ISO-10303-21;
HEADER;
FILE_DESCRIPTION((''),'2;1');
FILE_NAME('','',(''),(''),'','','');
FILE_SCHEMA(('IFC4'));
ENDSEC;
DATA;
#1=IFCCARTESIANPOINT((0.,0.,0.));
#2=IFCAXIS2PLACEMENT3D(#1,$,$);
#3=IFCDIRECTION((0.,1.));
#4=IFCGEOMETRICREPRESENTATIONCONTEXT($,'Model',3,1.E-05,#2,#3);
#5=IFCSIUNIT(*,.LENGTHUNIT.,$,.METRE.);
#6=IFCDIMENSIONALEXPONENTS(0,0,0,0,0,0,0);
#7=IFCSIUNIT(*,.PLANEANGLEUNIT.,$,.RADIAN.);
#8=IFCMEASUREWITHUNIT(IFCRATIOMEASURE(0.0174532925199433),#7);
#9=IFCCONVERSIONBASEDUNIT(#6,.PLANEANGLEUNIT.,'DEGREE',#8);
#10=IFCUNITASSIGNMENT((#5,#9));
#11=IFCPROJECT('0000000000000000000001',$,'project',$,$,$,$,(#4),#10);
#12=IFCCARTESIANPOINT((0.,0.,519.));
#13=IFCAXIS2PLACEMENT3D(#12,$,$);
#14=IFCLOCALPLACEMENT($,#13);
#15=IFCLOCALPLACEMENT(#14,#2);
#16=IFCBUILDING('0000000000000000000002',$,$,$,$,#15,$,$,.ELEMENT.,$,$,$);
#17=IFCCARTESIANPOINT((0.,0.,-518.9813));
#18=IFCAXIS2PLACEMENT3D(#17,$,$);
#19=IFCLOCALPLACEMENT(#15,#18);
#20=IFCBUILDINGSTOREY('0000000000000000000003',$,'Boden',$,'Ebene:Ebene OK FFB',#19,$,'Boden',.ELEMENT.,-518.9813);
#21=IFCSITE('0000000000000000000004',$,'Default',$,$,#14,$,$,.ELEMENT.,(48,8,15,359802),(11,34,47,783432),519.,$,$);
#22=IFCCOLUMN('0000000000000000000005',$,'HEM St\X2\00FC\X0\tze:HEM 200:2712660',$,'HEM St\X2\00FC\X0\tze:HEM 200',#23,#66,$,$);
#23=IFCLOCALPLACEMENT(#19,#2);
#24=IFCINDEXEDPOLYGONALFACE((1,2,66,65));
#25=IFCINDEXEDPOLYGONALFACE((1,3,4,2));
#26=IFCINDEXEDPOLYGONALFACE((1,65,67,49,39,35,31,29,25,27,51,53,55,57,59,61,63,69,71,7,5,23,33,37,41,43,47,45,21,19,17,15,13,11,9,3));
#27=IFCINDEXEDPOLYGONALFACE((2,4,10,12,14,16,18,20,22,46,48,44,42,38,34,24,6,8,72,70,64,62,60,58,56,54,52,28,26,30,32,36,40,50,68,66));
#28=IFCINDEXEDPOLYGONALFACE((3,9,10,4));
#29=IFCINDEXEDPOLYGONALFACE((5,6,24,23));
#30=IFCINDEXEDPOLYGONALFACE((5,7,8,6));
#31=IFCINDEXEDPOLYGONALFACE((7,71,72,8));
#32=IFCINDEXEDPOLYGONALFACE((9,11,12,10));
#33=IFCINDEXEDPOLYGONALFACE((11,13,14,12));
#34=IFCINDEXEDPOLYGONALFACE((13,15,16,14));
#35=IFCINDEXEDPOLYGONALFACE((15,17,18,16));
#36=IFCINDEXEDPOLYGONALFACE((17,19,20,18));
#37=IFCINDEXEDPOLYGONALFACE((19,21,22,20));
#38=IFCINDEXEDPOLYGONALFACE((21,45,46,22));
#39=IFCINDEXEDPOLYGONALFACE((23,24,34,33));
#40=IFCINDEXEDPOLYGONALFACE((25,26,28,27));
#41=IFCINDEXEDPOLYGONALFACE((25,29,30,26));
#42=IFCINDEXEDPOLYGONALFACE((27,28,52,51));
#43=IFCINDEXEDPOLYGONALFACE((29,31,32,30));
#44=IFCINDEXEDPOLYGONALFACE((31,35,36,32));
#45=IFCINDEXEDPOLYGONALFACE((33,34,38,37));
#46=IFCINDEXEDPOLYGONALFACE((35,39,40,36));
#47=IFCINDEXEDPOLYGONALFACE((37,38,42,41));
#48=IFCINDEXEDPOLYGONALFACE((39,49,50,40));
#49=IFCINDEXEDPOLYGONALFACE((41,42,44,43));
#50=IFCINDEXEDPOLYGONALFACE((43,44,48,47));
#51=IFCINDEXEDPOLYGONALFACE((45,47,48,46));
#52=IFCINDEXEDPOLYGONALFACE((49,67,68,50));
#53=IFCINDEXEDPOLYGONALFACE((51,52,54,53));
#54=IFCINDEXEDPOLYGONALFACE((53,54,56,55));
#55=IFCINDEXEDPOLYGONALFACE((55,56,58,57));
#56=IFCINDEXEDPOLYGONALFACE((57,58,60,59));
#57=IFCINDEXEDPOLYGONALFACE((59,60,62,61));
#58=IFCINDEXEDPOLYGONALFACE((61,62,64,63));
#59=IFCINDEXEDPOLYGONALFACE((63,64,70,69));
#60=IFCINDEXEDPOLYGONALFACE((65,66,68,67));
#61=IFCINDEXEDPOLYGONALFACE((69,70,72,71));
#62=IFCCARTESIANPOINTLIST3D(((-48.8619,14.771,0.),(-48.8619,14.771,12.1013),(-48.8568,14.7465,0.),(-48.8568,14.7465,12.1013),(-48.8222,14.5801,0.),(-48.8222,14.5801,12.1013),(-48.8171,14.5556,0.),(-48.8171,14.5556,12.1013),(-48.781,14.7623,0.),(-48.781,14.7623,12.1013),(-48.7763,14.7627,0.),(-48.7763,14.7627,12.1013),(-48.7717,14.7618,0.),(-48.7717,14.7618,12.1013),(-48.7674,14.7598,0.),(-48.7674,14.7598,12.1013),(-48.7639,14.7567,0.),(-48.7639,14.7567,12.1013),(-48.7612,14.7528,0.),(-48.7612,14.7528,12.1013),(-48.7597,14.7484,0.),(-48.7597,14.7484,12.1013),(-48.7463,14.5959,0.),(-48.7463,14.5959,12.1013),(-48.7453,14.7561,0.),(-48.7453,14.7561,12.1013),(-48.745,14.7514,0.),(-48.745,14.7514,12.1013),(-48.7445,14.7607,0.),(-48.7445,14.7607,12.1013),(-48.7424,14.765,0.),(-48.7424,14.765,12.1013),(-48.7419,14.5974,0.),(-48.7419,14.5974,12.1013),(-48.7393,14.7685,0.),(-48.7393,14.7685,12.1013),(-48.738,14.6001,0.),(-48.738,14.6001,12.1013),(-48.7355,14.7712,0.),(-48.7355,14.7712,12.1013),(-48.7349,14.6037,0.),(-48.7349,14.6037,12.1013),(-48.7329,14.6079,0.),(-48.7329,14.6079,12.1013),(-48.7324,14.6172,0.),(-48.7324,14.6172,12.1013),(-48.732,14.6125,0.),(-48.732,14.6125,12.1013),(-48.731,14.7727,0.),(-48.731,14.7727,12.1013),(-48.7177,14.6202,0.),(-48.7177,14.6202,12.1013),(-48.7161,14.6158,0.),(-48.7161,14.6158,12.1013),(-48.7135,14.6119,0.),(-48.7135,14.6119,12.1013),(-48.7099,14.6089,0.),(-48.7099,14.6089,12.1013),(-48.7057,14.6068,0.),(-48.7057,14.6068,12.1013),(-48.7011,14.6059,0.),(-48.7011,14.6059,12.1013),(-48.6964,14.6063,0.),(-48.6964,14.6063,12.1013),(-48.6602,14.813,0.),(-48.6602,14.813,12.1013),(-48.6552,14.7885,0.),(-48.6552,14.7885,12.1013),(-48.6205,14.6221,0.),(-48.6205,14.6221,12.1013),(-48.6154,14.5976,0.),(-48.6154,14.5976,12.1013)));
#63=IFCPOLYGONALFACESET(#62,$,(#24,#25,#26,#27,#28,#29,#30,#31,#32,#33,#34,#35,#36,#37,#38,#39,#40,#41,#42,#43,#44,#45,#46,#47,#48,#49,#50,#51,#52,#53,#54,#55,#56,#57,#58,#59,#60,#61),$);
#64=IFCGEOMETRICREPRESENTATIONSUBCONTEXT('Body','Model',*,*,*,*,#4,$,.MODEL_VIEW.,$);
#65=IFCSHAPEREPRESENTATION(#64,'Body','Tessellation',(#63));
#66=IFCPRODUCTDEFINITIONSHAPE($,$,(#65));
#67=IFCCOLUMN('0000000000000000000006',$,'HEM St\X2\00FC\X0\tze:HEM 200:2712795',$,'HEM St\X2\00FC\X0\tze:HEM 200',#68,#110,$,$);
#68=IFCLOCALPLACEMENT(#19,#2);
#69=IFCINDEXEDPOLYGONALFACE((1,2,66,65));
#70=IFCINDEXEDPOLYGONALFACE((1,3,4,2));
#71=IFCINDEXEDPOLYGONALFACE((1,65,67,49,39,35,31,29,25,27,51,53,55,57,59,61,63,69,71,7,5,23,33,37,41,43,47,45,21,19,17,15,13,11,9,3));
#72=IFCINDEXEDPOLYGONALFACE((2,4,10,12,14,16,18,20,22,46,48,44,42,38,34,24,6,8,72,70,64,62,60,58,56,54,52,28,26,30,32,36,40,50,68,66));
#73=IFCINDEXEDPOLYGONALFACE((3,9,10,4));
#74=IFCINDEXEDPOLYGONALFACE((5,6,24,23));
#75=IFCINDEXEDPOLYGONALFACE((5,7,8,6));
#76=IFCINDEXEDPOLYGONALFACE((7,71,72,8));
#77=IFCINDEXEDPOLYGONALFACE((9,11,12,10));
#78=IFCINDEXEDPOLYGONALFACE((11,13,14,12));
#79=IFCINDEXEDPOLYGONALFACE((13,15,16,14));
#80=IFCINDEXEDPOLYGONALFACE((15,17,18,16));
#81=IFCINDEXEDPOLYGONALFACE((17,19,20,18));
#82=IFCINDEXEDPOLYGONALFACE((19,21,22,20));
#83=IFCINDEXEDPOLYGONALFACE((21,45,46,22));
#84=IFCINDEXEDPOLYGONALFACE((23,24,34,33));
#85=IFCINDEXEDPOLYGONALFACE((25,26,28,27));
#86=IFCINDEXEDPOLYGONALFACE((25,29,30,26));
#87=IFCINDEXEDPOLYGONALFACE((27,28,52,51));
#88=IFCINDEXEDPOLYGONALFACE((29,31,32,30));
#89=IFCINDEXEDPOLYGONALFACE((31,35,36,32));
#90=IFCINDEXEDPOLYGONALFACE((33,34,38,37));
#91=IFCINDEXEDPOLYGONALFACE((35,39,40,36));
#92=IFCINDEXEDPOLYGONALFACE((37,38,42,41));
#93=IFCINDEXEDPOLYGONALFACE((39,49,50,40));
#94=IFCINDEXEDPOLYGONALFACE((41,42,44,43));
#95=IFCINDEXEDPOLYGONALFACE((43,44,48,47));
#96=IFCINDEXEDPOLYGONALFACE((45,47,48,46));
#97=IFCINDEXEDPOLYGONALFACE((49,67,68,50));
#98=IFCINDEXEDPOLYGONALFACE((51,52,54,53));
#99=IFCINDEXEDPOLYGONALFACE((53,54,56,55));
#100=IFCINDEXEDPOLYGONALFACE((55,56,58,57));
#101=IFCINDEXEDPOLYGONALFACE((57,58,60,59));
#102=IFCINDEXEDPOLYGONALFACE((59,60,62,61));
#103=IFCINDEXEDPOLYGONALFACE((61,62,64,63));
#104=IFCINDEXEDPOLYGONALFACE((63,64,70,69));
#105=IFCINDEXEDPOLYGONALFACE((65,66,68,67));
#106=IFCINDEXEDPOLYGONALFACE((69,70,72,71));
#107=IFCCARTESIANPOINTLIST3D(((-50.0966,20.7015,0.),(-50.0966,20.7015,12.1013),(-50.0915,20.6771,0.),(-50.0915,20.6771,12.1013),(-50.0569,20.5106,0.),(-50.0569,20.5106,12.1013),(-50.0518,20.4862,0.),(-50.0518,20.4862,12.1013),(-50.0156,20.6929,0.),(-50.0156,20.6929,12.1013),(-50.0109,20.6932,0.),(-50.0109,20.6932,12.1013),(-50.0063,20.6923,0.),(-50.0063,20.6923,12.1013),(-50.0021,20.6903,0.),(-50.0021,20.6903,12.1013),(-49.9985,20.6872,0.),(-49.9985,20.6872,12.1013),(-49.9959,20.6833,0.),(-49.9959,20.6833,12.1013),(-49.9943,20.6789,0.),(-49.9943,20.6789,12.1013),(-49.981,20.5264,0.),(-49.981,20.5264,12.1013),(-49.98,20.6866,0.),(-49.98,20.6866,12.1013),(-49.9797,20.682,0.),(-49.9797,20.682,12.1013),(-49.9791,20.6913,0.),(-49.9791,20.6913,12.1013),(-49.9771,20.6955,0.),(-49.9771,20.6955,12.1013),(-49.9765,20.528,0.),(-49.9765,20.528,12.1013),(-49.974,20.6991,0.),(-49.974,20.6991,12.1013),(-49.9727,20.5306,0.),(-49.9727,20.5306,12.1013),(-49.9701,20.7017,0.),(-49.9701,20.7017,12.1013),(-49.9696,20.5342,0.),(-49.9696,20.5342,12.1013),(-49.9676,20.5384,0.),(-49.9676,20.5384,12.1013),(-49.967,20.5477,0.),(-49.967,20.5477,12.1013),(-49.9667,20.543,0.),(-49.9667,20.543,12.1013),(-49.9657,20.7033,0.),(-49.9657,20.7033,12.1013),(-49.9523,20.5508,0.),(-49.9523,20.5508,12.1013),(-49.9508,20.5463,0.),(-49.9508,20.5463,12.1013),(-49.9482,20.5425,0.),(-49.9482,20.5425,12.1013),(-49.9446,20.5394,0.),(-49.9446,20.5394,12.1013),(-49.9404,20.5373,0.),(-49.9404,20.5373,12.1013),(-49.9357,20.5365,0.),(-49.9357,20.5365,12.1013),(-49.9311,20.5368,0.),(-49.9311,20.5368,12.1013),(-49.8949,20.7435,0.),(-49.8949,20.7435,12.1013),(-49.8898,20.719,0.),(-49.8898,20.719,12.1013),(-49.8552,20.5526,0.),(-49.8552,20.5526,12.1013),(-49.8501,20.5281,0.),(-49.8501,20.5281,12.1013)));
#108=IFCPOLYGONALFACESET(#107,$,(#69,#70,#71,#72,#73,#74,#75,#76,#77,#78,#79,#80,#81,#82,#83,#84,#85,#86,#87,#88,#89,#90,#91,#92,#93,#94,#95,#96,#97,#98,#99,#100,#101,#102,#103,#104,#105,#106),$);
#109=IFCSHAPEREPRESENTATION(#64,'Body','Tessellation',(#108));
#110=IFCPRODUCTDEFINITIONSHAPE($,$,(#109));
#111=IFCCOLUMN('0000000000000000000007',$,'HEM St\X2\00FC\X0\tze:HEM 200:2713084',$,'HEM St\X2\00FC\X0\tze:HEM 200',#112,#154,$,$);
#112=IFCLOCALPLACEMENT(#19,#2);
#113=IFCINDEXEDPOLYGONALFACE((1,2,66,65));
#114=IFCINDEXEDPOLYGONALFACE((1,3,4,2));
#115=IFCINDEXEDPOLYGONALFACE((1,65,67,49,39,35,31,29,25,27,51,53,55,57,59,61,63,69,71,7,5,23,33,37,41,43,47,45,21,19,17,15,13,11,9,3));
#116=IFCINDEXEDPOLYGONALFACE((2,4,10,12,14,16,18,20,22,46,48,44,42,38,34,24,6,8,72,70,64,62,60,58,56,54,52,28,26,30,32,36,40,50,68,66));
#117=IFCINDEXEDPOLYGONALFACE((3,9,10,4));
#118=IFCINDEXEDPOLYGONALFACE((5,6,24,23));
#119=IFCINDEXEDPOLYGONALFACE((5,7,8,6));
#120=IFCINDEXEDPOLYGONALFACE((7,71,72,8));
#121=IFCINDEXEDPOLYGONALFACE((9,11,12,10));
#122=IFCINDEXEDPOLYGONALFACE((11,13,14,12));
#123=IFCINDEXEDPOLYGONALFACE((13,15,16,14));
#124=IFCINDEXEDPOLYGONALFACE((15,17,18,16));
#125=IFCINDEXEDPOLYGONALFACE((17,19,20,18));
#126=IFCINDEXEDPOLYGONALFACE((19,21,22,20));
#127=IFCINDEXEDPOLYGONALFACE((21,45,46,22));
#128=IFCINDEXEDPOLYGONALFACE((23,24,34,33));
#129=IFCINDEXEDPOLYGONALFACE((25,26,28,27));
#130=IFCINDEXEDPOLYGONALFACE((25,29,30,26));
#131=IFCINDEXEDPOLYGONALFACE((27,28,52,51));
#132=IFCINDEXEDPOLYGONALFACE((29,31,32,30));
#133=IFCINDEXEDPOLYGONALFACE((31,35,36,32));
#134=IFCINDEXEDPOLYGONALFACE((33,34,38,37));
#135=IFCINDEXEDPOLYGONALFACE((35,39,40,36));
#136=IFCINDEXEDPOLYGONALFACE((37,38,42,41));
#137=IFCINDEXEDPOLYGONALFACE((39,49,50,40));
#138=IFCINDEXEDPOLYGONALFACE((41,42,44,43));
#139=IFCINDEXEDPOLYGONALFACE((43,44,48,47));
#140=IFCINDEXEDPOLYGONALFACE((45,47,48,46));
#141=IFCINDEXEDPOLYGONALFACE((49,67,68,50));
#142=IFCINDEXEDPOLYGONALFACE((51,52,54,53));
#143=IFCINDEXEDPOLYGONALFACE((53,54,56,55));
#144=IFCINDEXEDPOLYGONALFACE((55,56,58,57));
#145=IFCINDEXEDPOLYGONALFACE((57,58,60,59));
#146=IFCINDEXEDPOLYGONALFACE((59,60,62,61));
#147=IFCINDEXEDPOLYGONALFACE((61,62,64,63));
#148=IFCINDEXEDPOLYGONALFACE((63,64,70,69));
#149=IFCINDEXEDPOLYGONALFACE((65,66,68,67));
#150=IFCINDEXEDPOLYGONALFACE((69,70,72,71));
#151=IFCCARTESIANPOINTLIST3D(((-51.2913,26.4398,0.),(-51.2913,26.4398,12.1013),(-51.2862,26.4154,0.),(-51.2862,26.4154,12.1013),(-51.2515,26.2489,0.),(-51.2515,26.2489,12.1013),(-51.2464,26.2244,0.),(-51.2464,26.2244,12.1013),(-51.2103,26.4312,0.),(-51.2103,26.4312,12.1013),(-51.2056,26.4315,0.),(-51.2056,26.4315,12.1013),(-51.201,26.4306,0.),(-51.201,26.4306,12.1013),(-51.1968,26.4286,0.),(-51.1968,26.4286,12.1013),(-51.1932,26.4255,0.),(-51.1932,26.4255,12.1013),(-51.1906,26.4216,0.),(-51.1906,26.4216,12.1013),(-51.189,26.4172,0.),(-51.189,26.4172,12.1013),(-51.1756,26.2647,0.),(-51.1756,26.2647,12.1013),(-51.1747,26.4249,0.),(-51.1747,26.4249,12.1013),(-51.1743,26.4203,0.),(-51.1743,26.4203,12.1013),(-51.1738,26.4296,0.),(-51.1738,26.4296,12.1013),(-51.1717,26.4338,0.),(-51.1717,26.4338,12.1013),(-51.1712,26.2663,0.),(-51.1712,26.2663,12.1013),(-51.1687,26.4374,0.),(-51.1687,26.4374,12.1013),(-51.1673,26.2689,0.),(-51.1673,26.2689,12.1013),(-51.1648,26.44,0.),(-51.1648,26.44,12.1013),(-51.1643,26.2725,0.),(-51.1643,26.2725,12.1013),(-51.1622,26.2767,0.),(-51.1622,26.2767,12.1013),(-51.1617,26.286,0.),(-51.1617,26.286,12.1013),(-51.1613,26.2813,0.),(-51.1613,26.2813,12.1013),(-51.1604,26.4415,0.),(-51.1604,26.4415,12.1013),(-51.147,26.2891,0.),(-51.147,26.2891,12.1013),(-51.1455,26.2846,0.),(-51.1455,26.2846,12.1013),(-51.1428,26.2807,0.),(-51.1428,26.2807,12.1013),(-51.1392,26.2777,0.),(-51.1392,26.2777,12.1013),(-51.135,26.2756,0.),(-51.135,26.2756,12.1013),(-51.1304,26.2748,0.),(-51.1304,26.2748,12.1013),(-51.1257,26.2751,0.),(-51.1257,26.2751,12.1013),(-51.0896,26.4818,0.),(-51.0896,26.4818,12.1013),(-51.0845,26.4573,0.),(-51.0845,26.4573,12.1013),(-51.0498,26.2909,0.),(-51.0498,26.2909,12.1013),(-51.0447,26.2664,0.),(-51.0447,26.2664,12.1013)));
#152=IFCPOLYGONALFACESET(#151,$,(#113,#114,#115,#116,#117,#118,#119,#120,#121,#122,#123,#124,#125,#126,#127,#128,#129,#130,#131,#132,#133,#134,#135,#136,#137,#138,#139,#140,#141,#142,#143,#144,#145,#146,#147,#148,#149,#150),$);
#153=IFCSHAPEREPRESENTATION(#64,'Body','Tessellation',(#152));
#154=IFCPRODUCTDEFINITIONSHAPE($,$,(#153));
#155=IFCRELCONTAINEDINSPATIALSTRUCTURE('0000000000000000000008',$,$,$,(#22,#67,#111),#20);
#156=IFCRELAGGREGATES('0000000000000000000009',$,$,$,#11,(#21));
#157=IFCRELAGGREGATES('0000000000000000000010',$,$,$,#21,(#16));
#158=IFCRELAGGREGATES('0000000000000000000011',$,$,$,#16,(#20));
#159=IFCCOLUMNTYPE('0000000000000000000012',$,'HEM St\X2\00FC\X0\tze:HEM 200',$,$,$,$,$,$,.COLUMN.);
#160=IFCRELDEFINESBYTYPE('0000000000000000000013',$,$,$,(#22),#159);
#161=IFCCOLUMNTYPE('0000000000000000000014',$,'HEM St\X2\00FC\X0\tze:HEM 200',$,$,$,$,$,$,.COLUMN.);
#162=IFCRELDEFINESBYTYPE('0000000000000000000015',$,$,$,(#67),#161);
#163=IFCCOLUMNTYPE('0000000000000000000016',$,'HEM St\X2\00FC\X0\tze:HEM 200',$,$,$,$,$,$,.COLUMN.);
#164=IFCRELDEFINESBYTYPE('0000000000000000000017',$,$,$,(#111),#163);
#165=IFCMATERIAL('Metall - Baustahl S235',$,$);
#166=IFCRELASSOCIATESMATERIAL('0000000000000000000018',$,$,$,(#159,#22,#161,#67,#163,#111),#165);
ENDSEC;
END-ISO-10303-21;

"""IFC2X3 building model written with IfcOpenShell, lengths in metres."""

from ifc_helpers import new_model, entity, si_unit, converted_unit, direction, frame, frame_2d, origin, place, context, subcontext, project, spatial, polyline, circle_curve, parameter, trimmed, segment, composite_curve, outline, extrude, source, transform, mapped, material, type_object, type_shapes, element, save


model = new_model("IFC2X3")

# Units and contexts
model_context = context("Model", 3, precision=1e-05, world=origin(), true_north=direction((0.0, 1.0)))
body_context = subcontext(model_context, "Body", "Model", "MODEL_VIEW")
ifc_project = project(units=[si_unit("LENGTHUNIT", "METRE"), converted_unit("PLANEANGLEUNIT", "DEGREE", entity("IfcRatioMeasure", 0.0174532925199433), si_unit("PLANEANGLEUNIT", "RADIAN"), dimensions=[0, 0, 0, 0, 0, 0, 0])], contexts=[model_context])

# Site, building, storey
site_placement = place(None, frame((0.0, 0.0, 519.0)))
site = spatial("IfcSite", under=ifc_project, at=site_placement, Name="Default", CompositionType="ELEMENT", RefLatitude=(48, 8, 15, 359802), RefLongitude=(11, 34, 47, 783432), RefElevation=519.0)
building_placement = place(site_placement, origin())
building = spatial("IfcBuilding", under=site, at=building_placement, CompositionType="ELEMENT")
storey_placement = place(building_placement, frame((0.0, 0.0, -518.9813)))
storey = spatial("IfcBuildingStorey", under=building, at=storey_placement, Name="Boden", ObjectType="Ebene:Ebene OK FFB", LongName="Boden", CompositionType="ELEMENT", Elevation=-518.9813)

# Columns
ifc_material_1 = material(Name="Metall - Baustahl S235")
column_type_1 = type_object("IfcColumnType", Name="HEM Stütze:HEM 200", PredefinedType="COLUMN", material=ifc_material_1)
shared_shape_1 = source(origin(), body_context, "Body", "SweptSolid", [
    extrude(outline(composite_curve([segment(polyline([(0.085, -0.103), (0.11, -0.103)]), True, "CONTINUOUS"), segment(polyline([(0.11, -0.103), (0.11, 0.103)]), True, "CONTINUOUS"), segment(polyline([(0.11, 0.103), (0.085, 0.103)]), True, "CONTINUOUS"), segment(polyline([(0.085, 0.103), (0.085, 0.0255)]), True, "CONTINUOUS"), segment(trimmed(circle_curve(frame_2d((0.067, 0.0255), x_axis=(1.0, 0.0)), 0.018), [parameter(270.0)], [parameter(0.0)], True, "PARAMETER"), False, "CONTINUOUS"), segment(polyline([(0.067, 0.0075), (-0.067, 0.0075)]), True, "CONTINUOUS"), segment(trimmed(circle_curve(frame_2d((-0.067, 0.0255), x_axis=(0.0, -1.0)), 0.018), [parameter(270.0)], [parameter(0.0)], True, "PARAMETER"), False, "CONTINUOUS"), segment(polyline([(-0.085, 0.0255), (-0.085, 0.103)]), True, "CONTINUOUS"), segment(polyline([(-0.085, 0.103), (-0.11, 0.103)]), True, "CONTINUOUS"), segment(polyline([(-0.11, 0.103), (-0.11, -0.103)]), True, "CONTINUOUS"), segment(polyline([(-0.11, -0.103), (-0.085, -0.103)]), True, "CONTINUOUS"), segment(polyline([(-0.085, -0.103), (-0.085, -0.0255)]), True, "CONTINUOUS"), segment(trimmed(circle_curve(frame_2d((-0.067, -0.0255), x_axis=(-1.0, 0.0)), 0.018), [parameter(270.0)], [parameter(0.0)], True, "PARAMETER"), False, "CONTINUOUS"), segment(polyline([(-0.067, -0.0075), (0.067, -0.0075)]), True, "CONTINUOUS"), segment(trimmed(circle_curve(frame_2d((0.067, -0.0255), x_axis=(0.0, 1.0)), 0.018), [parameter(270.0)], [parameter(0.0)], True, "PARAMETER"), False, "CONTINUOUS"), segment(polyline([(0.085, -0.0255), (0.085, -0.103)]), True, "CONTINUOUS")], self_intersect=False)), frame((-48.7387, 14.6843, -518.9813), z_axis=(0.0, 0.0, 1.0), x_axis=(-0.20382, 0.979008, 0.0)), (0.0, 0.0, 1.0), 12.1013),
])
type_shapes(column_type_1, [shared_shape_1])
column_1_placement = place(storey_placement, frame((0.0, 0.0, 518.9813)))
element("IfcColumn", 1, at=column_1_placement, inside=storey, type_object=column_type_1, material=ifc_material_1, Name="HEM Stütze:HEM 200:2712660", ObjectType="HEM Stütze:HEM 200", context=body_context, shape_type="MappedRepresentation", body=[
    mapped(shared_shape_1, transform((0.0, 0.0, 0.0), scale=1.0)),
])
column_type_2 = type_object("IfcColumnType", Name="HEM Stütze:HEM 200", PredefinedType="COLUMN", material=ifc_material_1)
shared_shape_2 = source(origin(), body_context, "Body", "SweptSolid", [
    extrude(outline(composite_curve([segment(polyline([(0.085, -0.103), (0.11, -0.103)]), True, "CONTINUOUS"), segment(polyline([(0.11, -0.103), (0.11, 0.103)]), True, "CONTINUOUS"), segment(polyline([(0.11, 0.103), (0.085, 0.103)]), True, "CONTINUOUS"), segment(polyline([(0.085, 0.103), (0.085, 0.0255)]), True, "CONTINUOUS"), segment(trimmed(circle_curve(frame_2d((0.067, 0.0255), x_axis=(1.0, 0.0)), 0.018), [parameter(270.0)], [parameter(0.0)], True, "PARAMETER"), False, "CONTINUOUS"), segment(polyline([(0.067, 0.0075), (-0.067, 0.0075)]), True, "CONTINUOUS"), segment(trimmed(circle_curve(frame_2d((-0.067, 0.0255), x_axis=(0.0, -1.0)), 0.018), [parameter(270.0)], [parameter(0.0)], True, "PARAMETER"), False, "CONTINUOUS"), segment(polyline([(-0.085, 0.0255), (-0.085, 0.103)]), True, "CONTINUOUS"), segment(polyline([(-0.085, 0.103), (-0.11, 0.103)]), True, "CONTINUOUS"), segment(polyline([(-0.11, 0.103), (-0.11, -0.103)]), True, "CONTINUOUS"), segment(polyline([(-0.11, -0.103), (-0.085, -0.103)]), True, "CONTINUOUS"), segment(polyline([(-0.085, -0.103), (-0.085, -0.0255)]), True, "CONTINUOUS"), segment(trimmed(circle_curve(frame_2d((-0.067, -0.0255), x_axis=(-1.0, 0.0)), 0.018), [parameter(270.0)], [parameter(0.0)], True, "PARAMETER"), False, "CONTINUOUS"), segment(polyline([(-0.067, -0.0075), (0.067, -0.0075)]), True, "CONTINUOUS"), segment(trimmed(circle_curve(frame_2d((0.067, -0.0255), x_axis=(0.0, 1.0)), 0.018), [parameter(270.0)], [parameter(0.0)], True, "PARAMETER"), False, "CONTINUOUS"), segment(polyline([(0.085, -0.0255), (0.085, -0.103)]), True, "CONTINUOUS")], self_intersect=False)), frame((-49.9733, 20.6148, -518.9813), z_axis=(0.0, 0.0, 1.0), x_axis=(-0.20382, 0.979008, 0.0)), (0.0, 0.0, 1.0), 12.1013),
])
type_shapes(column_type_2, [shared_shape_2])
column_2_placement = place(storey_placement, frame((0.0, 0.0, 518.9813)))
element("IfcColumn", 2, at=column_2_placement, inside=storey, type_object=column_type_2, material=ifc_material_1, Name="HEM Stütze:HEM 200:2712795", ObjectType="HEM Stütze:HEM 200", context=body_context, shape_type="MappedRepresentation", body=[
    mapped(shared_shape_2, transform((0.0, 0.0, 0.0), scale=1.0)),
])
column_type_3 = type_object("IfcColumnType", Name="HEM Stütze:HEM 200", PredefinedType="COLUMN", material=ifc_material_1)
shared_shape_3 = source(origin(), body_context, "Body", "SweptSolid", [
    extrude(outline(composite_curve([segment(polyline([(0.085, -0.103), (0.11, -0.103)]), True, "CONTINUOUS"), segment(polyline([(0.11, -0.103), (0.11, 0.103)]), True, "CONTINUOUS"), segment(polyline([(0.11, 0.103), (0.085, 0.103)]), True, "CONTINUOUS"), segment(polyline([(0.085, 0.103), (0.085, 0.0255)]), True, "CONTINUOUS"), segment(trimmed(circle_curve(frame_2d((0.067, 0.0255), x_axis=(1.0, 0.0)), 0.018), [parameter(270.0)], [parameter(0.0)], True, "PARAMETER"), False, "CONTINUOUS"), segment(polyline([(0.067, 0.0075), (-0.067, 0.0075)]), True, "CONTINUOUS"), segment(trimmed(circle_curve(frame_2d((-0.067, 0.0255), x_axis=(0.0, -1.0)), 0.018), [parameter(270.0)], [parameter(0.0)], True, "PARAMETER"), False, "CONTINUOUS"), segment(polyline([(-0.085, 0.0255), (-0.085, 0.103)]), True, "CONTINUOUS"), segment(polyline([(-0.085, 0.103), (-0.11, 0.103)]), True, "CONTINUOUS"), segment(polyline([(-0.11, 0.103), (-0.11, -0.103)]), True, "CONTINUOUS"), segment(polyline([(-0.11, -0.103), (-0.085, -0.103)]), True, "CONTINUOUS"), segment(polyline([(-0.085, -0.103), (-0.085, -0.0255)]), True, "CONTINUOUS"), segment(trimmed(circle_curve(frame_2d((-0.067, -0.0255), x_axis=(-1.0, 0.0)), 0.018), [parameter(270.0)], [parameter(0.0)], True, "PARAMETER"), False, "CONTINUOUS"), segment(polyline([(-0.067, -0.0075), (0.067, -0.0075)]), True, "CONTINUOUS"), segment(trimmed(circle_curve(frame_2d((0.067, -0.0255), x_axis=(0.0, 1.0)), 0.018), [parameter(270.0)], [parameter(0.0)], True, "PARAMETER"), False, "CONTINUOUS"), segment(polyline([(0.085, -0.0255), (0.085, -0.103)]), True, "CONTINUOUS")], self_intersect=False)), frame((-51.168, 26.3531, -518.9813), z_axis=(0.0, 0.0, 1.0), x_axis=(-0.20382, 0.979008, 0.0)), (0.0, 0.0, 1.0), 12.1013),
])
type_shapes(column_type_3, [shared_shape_3])
column_3_placement = place(storey_placement, frame((0.0, 0.0, 518.9813)))
element("IfcColumn", 3, at=column_3_placement, inside=storey, type_object=column_type_3, material=ifc_material_1, Name="HEM Stütze:HEM 200:2713084", ObjectType="HEM Stütze:HEM 200", context=body_context, shape_type="MappedRepresentation", body=[
    mapped(shared_shape_3, transform((0.0, 0.0, 0.0), scale=1.0)),
])

save(model, "model.ifc")
